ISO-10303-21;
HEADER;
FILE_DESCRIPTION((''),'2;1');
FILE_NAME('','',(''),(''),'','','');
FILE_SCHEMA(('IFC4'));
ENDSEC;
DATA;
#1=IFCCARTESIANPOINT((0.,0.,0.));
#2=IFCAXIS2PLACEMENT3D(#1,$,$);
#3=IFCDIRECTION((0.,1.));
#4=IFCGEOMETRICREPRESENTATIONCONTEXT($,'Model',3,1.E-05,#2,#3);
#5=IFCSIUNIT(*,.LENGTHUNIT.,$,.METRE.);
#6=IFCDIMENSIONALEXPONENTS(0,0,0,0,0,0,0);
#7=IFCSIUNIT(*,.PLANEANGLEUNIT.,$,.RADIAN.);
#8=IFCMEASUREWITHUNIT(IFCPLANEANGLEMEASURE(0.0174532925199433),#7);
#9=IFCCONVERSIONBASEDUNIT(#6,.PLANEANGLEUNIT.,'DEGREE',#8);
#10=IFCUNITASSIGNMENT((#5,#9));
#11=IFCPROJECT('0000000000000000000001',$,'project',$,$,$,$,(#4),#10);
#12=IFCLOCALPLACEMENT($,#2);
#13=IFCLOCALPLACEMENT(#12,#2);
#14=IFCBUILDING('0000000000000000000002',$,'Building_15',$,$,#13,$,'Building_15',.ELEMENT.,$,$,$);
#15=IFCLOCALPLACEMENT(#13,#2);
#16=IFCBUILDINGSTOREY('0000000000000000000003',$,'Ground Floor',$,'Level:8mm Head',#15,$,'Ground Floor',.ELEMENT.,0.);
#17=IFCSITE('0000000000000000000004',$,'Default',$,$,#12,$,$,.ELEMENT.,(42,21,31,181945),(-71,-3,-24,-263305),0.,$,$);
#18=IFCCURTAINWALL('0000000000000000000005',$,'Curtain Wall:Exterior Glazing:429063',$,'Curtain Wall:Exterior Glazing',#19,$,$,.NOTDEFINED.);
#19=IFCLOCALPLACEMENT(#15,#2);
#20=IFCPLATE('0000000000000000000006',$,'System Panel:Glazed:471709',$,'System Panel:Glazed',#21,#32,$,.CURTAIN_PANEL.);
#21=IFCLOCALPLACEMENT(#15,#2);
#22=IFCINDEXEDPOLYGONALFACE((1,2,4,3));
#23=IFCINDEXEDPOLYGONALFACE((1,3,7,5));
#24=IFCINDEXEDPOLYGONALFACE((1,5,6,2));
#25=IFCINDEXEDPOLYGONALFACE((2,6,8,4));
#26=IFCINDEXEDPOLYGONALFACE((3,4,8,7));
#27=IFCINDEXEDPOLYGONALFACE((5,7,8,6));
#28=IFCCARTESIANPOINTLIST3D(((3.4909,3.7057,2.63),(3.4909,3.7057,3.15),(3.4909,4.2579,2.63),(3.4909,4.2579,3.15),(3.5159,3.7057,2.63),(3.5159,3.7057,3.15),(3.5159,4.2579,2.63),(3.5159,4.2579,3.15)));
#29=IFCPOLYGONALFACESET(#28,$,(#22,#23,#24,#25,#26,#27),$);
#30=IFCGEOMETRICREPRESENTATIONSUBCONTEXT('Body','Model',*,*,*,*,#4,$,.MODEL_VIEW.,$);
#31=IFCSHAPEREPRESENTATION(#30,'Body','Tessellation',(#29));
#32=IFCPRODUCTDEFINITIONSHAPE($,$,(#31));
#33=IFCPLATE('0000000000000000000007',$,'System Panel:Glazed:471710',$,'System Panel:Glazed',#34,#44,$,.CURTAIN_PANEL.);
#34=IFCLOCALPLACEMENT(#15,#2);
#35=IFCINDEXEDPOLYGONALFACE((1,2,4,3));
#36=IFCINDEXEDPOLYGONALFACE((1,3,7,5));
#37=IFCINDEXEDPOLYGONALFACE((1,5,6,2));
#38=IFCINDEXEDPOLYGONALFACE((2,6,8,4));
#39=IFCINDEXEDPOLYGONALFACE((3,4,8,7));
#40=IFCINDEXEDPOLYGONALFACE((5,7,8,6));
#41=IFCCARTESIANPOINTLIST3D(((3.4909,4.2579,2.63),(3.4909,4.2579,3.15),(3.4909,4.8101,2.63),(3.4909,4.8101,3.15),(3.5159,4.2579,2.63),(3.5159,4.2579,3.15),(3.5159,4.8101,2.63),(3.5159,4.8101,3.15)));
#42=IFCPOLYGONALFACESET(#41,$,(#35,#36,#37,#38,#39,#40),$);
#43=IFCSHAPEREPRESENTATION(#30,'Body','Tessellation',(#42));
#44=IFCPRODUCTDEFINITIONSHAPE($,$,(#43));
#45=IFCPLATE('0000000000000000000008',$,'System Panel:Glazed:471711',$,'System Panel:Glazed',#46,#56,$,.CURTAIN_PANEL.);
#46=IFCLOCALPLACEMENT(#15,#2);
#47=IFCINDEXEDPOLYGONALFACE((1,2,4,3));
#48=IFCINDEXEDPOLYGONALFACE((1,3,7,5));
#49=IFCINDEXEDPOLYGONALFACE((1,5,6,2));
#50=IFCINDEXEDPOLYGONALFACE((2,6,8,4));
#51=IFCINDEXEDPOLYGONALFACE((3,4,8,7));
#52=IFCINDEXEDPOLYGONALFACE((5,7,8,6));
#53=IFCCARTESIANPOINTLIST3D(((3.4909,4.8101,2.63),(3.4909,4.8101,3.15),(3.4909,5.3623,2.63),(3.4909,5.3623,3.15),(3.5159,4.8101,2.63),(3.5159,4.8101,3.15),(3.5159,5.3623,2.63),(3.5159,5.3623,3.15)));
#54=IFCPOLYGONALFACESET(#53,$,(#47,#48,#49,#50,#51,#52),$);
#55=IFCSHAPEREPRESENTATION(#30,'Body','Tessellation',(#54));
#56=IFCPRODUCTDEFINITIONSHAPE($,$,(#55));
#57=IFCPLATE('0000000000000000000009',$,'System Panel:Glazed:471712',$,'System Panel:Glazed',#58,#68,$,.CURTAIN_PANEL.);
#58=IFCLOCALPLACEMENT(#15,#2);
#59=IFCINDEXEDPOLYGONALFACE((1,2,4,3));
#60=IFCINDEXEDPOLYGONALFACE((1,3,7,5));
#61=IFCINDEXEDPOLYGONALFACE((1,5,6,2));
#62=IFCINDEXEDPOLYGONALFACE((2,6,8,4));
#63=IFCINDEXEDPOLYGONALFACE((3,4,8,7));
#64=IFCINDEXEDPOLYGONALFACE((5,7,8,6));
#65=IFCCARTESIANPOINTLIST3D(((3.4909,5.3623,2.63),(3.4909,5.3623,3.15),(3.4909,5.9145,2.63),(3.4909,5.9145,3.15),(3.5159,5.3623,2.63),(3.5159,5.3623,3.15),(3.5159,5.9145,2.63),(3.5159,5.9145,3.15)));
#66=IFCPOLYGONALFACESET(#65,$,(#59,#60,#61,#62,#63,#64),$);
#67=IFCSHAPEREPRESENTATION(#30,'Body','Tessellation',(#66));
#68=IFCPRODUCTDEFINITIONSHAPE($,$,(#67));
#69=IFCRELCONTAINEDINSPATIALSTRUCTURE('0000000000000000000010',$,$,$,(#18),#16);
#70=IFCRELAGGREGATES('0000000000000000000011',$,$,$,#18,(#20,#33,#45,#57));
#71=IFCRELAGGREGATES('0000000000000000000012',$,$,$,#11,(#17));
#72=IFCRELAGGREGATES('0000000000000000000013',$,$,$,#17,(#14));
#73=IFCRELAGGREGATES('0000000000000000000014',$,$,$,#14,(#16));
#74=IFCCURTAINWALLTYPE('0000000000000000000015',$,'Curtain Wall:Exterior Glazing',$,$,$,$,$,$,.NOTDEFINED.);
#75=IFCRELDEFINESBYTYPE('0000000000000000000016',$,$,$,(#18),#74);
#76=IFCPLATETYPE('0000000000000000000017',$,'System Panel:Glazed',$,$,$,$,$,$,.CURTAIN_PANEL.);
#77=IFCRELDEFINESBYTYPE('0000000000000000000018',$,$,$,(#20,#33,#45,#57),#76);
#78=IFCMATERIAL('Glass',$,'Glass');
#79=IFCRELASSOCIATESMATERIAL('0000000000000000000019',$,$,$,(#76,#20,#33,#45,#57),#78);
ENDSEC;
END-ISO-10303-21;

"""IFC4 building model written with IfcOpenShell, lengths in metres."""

from ifc_helpers import new_model, entity, si_unit, converted_unit, direction, frame, origin, place, context, subcontext, project, spatial, indexed_curve, outline, extrude, source, transform, mapped, material, type_object, type_shapes, element, aggregate, save


model = new_model("IFC4")

# Units and contexts
model_context = context("Model", 3, precision=1e-05, world=origin(), true_north=direction((0.0, 1.0)))
body_context = subcontext(model_context, "Body", "Model", "MODEL_VIEW")
ifc_project = project(units=[si_unit("LENGTHUNIT", "METRE"), converted_unit("PLANEANGLEUNIT", "DEGREE", entity("IfcPlaneAngleMeasure", 0.0174532925199433), si_unit("PLANEANGLEUNIT", "RADIAN"), dimensions=[0, 0, 0, 0, 0, 0, 0])], contexts=[model_context])

# Site, building, storey
site_placement = place(None, origin())
site = spatial("IfcSite", under=ifc_project, at=site_placement, Name="Default", CompositionType="ELEMENT", RefLatitude=(42, 21, 31, 181945), RefLongitude=(-71, -3, -24, -263305), RefElevation=0.0)
building_placement = place(site_placement, origin())
building = spatial("IfcBuilding", under=site, at=building_placement, Name="Building_15", LongName="Building_15", CompositionType="ELEMENT")
storey_placement = place(building_placement, origin())
storey = spatial("IfcBuildingStorey", under=building, at=storey_placement, Name="Ground Floor", ObjectType="Level:8mm Head", LongName="Ground Floor", CompositionType="ELEMENT", Elevation=0.0)

# Curtain wall, plates
curtain_wall_type = type_object("IfcCurtainWallType", Name="Curtain Wall:Exterior Glazing", PredefinedType="NOTDEFINED")
curtain_wall_placement = place(storey_placement, origin())
curtain_wall = element("IfcCurtainWall", 1, at=curtain_wall_placement, inside=storey, type_object=curtain_wall_type, Name="Curtain Wall:Exterior Glazing:429063", ObjectType="Curtain Wall:Exterior Glazing", PredefinedType="NOTDEFINED")
ifc_material_1 = material(Name="Glass", Category="Glass")
plate_type_1 = type_object("IfcPlateType", Name="System Panel:Glazed", PredefinedType="CURTAIN_PANEL", material=ifc_material_1)
shared_shape_1 = source(origin(), body_context, "Body", "SweptSolid", [
    extrude(outline(indexed_curve([(-0.0125, -0.2761), (0.0125, -0.2761), (0.0125, 0.2761), (-0.0125, 0.2761), (-0.0125, -0.2761)], self_intersect=False)), frame((0.0, 0.037, 0.0), z_axis=(0.0, 0.0, 1.0), x_axis=(0.0, 1.0, 0.0)), (0.0, 0.0, 1.0), 0.52),
])
type_shapes(plate_type_1, [shared_shape_1])
plate_1_placement = place(curtain_wall_placement, frame((3.5404, 3.9818, 2.63), z_axis=(0.0, 0.0, 1.0), x_axis=(0.0, 1.0, 0.0)))
plate_1 = element("IfcPlate", 2, at=plate_1_placement, type_object=plate_type_1, material=ifc_material_1, Name="System Panel:Glazed:471709", ObjectType="System Panel:Glazed", PredefinedType="CURTAIN_PANEL", context=body_context, shape_type="MappedRepresentation", body=[
    mapped(shared_shape_1, transform((0.0, 0.0, 0.0), scale=1.0)),
])
plate_2_placement = place(curtain_wall_placement, frame((3.5404, 4.534, 2.63), z_axis=(0.0, 0.0, 1.0), x_axis=(0.0, 1.0, 0.0)))
plate_2 = element("IfcPlate", 3, at=plate_2_placement, type_object=plate_type_1, material=ifc_material_1, Name="System Panel:Glazed:471710", ObjectType="System Panel:Glazed", PredefinedType="CURTAIN_PANEL", context=body_context, shape_type="MappedRepresentation", body=[
    mapped(shared_shape_1, transform((0.0, 0.0, 0.0), scale=1.0)),
])
plate_3_placement = place(curtain_wall_placement, frame((3.5404, 5.0862, 2.63), z_axis=(0.0, 0.0, 1.0), x_axis=(0.0, 1.0, 0.0)))
plate_3 = element("IfcPlate", 4, at=plate_3_placement, type_object=plate_type_1, material=ifc_material_1, Name="System Panel:Glazed:471711", ObjectType="System Panel:Glazed", PredefinedType="CURTAIN_PANEL", context=body_context, shape_type="MappedRepresentation", body=[
    mapped(shared_shape_1, transform((0.0, 0.0, 0.0), scale=1.0)),
])
plate_4_placement = place(curtain_wall_placement, frame((3.5404, 5.6384, 2.63), z_axis=(0.0, 0.0, 1.0), x_axis=(0.0, 1.0, 0.0)))
plate_4 = element("IfcPlate", 5, at=plate_4_placement, type_object=plate_type_1, material=ifc_material_1, Name="System Panel:Glazed:471712", ObjectType="System Panel:Glazed", PredefinedType="CURTAIN_PANEL", context=body_context, shape_type="MappedRepresentation", body=[
    mapped(shared_shape_1, transform((0.0, 0.0, 0.0), scale=1.0)),
])
aggregate(curtain_wall, [plate_1, plate_2, plate_3, plate_4])

save(model, "model.ifc")
